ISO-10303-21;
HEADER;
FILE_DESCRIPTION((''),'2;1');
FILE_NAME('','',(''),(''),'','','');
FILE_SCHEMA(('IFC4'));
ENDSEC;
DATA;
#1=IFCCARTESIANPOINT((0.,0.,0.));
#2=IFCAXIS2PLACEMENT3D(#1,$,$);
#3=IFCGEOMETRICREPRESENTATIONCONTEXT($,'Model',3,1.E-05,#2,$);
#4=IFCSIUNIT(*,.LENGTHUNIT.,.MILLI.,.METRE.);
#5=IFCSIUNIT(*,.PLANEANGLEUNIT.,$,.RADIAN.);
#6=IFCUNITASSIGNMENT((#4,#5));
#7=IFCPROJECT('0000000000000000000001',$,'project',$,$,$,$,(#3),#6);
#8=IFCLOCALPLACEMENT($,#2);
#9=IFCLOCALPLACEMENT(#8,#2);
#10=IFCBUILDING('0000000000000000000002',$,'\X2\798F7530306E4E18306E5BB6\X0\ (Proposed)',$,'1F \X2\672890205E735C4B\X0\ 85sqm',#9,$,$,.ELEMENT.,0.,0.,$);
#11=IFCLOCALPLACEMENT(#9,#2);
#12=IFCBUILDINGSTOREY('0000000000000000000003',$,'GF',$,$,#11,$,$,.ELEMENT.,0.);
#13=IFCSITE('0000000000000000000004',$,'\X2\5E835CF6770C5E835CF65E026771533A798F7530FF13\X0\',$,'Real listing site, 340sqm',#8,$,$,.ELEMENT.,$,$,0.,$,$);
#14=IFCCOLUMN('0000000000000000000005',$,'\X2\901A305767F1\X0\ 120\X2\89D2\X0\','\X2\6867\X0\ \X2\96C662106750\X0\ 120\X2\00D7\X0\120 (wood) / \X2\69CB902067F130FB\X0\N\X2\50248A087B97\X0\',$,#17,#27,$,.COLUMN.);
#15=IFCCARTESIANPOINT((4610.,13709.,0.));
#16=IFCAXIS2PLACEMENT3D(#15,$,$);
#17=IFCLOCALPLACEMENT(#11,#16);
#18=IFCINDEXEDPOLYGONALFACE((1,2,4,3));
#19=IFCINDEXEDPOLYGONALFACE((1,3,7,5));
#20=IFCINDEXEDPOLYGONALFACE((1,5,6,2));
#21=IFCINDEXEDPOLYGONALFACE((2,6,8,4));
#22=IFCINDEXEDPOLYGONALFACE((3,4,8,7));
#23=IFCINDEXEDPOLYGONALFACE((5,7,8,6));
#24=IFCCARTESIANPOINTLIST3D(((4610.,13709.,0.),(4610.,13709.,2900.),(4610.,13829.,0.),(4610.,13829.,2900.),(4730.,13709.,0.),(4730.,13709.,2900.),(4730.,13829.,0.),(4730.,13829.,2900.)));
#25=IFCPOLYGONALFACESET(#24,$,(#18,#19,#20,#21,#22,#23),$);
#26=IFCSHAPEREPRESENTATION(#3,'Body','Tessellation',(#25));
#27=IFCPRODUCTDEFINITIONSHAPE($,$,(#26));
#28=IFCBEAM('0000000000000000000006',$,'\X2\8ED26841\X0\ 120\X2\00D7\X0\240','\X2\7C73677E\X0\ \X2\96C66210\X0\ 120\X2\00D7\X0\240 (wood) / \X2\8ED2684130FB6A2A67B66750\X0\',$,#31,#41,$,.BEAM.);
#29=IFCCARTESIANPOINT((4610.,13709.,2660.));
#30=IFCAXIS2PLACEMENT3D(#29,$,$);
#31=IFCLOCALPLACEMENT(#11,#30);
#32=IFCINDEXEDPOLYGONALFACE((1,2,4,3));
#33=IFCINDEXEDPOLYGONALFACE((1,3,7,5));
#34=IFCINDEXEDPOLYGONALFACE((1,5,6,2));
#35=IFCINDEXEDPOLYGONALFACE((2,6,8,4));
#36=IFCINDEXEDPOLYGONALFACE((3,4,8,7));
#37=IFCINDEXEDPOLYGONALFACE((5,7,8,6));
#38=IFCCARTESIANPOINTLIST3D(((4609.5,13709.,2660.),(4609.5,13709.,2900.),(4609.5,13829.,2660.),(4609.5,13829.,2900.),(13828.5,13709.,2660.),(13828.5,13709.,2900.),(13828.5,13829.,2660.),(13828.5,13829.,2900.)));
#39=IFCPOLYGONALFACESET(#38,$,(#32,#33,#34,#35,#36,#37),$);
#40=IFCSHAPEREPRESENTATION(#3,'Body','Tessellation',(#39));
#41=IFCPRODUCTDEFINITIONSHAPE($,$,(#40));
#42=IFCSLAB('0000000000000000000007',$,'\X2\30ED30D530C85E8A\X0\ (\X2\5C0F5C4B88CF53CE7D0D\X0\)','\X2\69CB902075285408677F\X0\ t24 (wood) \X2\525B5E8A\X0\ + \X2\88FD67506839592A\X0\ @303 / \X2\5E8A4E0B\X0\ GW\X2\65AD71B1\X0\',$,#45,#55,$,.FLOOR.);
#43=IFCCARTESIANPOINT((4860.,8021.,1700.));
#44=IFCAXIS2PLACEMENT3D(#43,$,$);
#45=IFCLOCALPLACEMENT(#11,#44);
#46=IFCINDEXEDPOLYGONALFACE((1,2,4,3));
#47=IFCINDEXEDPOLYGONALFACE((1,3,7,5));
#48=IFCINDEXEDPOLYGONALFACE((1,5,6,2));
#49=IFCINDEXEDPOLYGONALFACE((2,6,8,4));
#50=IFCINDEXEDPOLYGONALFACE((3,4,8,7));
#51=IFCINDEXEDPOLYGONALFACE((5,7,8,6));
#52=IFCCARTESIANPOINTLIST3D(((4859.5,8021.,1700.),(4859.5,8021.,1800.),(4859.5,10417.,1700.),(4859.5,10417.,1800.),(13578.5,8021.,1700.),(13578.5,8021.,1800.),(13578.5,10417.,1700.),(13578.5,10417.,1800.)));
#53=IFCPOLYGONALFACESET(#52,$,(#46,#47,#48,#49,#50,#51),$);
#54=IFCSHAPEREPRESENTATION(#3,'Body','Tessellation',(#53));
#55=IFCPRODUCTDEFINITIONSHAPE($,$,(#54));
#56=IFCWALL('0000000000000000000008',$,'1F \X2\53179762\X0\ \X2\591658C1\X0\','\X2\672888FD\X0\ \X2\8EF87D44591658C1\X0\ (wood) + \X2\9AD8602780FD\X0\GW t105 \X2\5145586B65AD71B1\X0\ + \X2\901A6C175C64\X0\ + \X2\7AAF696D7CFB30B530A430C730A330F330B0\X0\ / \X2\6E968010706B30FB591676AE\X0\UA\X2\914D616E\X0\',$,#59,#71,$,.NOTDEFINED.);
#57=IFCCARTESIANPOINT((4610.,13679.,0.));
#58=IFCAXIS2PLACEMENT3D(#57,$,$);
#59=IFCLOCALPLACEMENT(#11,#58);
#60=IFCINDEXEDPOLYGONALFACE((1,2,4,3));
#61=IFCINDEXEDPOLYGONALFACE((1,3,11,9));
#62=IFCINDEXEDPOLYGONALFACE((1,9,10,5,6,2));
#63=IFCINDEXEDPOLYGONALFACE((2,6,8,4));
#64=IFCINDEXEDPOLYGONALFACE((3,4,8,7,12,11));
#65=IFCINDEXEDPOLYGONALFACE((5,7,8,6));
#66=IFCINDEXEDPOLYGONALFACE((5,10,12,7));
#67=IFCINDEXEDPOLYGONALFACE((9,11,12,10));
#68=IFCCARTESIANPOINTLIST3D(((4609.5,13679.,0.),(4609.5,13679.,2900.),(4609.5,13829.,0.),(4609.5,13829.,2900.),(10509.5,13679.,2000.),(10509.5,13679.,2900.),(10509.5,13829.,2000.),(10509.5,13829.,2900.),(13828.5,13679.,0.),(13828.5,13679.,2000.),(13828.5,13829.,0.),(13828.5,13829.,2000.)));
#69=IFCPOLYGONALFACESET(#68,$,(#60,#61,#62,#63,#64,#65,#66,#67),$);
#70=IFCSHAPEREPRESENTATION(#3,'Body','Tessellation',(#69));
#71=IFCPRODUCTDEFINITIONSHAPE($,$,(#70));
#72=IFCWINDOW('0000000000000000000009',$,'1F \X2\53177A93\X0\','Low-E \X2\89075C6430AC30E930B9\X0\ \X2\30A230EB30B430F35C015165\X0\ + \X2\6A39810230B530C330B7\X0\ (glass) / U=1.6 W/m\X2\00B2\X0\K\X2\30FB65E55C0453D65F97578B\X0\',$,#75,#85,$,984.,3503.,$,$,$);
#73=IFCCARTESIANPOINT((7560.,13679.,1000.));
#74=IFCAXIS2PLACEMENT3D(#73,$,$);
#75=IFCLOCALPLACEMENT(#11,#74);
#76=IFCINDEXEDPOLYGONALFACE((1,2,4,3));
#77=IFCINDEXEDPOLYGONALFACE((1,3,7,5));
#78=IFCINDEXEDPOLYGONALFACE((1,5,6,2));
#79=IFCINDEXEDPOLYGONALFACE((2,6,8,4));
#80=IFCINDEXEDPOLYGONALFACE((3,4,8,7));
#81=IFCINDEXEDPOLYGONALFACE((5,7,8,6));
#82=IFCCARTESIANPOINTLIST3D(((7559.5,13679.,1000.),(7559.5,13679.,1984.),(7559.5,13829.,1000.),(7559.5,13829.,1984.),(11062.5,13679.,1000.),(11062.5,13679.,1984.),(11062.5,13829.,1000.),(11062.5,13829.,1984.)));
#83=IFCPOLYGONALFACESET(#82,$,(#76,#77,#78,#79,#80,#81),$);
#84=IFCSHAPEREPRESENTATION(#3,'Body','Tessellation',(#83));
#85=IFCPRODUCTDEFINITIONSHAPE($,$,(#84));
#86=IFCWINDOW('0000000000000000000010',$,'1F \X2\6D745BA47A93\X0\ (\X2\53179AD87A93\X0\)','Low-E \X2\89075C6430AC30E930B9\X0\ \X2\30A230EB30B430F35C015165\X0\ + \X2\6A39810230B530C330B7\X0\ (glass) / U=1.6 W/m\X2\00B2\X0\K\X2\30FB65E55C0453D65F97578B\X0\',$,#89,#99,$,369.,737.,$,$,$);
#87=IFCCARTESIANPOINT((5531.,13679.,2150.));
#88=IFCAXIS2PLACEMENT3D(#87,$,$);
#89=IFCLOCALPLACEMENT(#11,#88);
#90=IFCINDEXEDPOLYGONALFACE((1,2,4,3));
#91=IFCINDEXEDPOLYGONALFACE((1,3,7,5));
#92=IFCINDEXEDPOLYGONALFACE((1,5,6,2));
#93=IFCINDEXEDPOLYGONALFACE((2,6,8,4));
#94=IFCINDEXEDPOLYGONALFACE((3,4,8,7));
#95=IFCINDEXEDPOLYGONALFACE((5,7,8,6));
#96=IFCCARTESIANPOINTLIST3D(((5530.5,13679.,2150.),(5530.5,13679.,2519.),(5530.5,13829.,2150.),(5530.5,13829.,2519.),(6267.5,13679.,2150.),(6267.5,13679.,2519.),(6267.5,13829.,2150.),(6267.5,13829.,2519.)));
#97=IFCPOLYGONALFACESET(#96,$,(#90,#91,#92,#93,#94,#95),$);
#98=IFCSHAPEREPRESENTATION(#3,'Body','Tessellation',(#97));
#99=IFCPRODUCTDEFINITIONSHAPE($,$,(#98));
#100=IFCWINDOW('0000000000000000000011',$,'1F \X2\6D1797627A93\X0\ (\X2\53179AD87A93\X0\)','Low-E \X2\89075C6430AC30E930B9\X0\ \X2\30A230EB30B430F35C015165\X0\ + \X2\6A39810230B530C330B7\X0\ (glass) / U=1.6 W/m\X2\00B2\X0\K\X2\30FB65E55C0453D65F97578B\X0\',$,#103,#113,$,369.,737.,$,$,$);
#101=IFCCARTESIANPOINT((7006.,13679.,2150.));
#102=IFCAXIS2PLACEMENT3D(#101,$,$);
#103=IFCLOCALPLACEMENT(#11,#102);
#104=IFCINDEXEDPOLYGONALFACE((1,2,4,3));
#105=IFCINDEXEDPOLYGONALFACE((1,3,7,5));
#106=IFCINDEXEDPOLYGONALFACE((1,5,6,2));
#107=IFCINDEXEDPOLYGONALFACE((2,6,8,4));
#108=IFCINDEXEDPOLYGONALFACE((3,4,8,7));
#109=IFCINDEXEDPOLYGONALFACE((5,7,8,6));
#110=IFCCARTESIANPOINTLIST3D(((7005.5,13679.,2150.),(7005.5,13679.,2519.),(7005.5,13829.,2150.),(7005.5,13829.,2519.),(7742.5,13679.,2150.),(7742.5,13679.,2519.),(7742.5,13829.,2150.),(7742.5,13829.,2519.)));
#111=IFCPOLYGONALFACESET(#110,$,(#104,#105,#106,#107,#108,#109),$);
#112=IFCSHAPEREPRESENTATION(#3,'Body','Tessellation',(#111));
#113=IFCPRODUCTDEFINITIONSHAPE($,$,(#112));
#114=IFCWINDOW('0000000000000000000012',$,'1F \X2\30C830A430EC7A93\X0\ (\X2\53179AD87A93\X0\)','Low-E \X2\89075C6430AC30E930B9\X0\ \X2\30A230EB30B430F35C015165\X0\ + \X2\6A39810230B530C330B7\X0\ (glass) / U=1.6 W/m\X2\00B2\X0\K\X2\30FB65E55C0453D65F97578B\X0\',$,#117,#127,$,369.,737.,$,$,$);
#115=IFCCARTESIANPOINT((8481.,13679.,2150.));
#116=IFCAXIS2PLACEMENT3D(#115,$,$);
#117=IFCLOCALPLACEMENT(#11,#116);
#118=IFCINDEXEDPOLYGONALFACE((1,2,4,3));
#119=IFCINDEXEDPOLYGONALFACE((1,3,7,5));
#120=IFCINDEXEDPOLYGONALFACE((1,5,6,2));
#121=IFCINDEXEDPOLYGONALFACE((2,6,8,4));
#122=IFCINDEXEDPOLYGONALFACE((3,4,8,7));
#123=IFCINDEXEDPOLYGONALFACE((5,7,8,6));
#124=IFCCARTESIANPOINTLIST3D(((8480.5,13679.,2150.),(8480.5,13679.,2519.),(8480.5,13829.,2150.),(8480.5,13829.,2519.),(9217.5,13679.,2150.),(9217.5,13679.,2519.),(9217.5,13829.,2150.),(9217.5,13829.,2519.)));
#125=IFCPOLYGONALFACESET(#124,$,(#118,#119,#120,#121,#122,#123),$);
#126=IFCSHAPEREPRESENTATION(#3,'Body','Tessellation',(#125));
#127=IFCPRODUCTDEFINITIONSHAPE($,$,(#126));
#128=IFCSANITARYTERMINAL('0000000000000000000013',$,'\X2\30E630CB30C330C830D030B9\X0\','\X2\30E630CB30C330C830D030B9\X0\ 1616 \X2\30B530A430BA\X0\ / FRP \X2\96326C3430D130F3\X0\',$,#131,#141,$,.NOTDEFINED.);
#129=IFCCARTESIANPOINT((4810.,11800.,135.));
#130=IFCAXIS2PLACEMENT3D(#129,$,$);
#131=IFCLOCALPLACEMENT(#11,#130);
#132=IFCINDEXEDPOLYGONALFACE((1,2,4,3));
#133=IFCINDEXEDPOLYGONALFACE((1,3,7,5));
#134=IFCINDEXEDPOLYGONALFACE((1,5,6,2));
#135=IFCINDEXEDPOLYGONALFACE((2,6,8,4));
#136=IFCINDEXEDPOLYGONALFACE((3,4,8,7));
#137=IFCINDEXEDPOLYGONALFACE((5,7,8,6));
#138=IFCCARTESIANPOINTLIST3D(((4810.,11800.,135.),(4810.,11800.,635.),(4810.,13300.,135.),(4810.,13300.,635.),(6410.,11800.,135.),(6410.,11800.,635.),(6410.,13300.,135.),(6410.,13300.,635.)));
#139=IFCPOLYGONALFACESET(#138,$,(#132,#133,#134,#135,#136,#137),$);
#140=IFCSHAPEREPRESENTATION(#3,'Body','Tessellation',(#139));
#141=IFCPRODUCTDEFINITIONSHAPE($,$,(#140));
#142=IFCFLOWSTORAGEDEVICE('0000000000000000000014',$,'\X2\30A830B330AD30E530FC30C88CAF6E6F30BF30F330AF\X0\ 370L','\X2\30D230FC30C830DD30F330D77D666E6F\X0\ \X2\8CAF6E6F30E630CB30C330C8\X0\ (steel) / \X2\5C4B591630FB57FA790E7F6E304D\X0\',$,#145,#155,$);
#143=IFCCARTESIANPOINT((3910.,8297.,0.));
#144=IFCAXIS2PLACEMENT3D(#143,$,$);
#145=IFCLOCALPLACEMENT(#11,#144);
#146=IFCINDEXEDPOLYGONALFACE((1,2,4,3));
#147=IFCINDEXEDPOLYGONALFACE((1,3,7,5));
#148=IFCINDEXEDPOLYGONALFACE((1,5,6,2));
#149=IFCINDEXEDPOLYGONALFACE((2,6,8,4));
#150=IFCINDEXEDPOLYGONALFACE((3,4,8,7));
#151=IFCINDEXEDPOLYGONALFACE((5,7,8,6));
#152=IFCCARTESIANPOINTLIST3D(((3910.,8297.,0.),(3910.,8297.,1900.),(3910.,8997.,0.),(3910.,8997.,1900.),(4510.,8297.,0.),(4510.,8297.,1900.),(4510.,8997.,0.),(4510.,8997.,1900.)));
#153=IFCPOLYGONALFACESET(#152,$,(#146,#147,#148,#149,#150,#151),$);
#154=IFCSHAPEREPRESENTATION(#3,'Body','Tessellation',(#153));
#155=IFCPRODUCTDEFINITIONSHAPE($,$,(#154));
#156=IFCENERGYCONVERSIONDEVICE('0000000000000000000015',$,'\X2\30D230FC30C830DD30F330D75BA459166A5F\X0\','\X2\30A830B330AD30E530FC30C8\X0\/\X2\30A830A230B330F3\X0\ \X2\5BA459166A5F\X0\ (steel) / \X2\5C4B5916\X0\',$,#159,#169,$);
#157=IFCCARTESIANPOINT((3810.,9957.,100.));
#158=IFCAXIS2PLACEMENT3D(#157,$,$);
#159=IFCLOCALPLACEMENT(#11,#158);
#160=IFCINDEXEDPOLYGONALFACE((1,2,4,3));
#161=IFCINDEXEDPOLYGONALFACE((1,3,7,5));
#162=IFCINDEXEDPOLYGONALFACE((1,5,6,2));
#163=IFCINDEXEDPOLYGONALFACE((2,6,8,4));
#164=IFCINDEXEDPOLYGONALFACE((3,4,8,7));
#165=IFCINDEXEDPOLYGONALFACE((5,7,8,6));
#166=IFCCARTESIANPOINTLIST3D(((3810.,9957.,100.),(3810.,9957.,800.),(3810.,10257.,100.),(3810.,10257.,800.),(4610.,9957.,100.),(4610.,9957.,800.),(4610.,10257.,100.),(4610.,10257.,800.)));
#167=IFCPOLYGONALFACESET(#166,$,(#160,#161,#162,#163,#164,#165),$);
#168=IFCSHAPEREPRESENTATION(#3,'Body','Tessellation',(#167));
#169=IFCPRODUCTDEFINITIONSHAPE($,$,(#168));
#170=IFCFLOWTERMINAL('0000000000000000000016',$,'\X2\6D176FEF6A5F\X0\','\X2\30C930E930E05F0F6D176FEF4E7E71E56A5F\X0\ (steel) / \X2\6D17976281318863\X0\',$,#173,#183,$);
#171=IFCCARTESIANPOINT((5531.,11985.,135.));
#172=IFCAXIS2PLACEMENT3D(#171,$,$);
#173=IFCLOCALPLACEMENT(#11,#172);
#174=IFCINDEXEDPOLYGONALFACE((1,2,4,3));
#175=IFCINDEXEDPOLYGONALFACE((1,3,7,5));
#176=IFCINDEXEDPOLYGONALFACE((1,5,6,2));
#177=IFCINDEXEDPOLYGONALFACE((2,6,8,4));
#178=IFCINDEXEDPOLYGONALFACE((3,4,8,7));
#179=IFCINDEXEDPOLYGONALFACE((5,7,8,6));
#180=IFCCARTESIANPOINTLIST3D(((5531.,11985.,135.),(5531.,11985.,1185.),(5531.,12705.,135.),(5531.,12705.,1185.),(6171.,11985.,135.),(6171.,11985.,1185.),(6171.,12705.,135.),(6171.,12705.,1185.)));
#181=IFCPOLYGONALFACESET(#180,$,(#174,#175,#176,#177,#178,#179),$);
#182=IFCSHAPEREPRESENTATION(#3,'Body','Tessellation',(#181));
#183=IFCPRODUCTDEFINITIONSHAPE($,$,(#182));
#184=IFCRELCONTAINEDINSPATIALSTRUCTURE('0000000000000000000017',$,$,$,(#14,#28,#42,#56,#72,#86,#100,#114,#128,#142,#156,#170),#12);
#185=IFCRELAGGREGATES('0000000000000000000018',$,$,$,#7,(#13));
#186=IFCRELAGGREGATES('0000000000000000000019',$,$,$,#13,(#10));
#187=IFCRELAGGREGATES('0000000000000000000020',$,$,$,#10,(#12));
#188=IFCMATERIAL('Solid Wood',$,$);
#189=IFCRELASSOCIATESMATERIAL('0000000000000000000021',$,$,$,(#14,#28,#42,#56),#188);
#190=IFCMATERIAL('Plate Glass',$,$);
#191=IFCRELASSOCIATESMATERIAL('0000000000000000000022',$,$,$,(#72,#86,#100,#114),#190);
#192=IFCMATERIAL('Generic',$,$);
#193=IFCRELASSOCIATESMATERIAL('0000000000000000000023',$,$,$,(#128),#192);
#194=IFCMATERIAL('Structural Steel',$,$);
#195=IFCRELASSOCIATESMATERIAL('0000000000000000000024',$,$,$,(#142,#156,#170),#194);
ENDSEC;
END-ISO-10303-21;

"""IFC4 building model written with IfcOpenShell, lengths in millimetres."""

from ifc_helpers import new_model, si_unit, frame, frame_2d, origin, place, context, project, spatial, rectangle, extrude, material, element, fill, save


model = new_model("IFC4")

# Units and contexts
model_context = context("Model", 3, precision=1e-05, world=origin())
ifc_project = project(units=[si_unit("LENGTHUNIT", "METRE", prefix="MILLI"), si_unit("PLANEANGLEUNIT", "RADIAN")], contexts=[model_context])

# Site, building, storey
site_placement = place(None, origin())
site = spatial("IfcSite", under=ifc_project, at=site_placement, Name="広島県広島市東区福田３", ObjectType="Real listing site, 340sqm", CompositionType="ELEMENT", RefElevation=0.0)
building_placement = place(site_placement, origin())
building = spatial("IfcBuilding", under=site, at=building_placement, Name="福田の丘の家 (Proposed)", ObjectType="1F 木造平屋 85sqm", CompositionType="ELEMENT", ElevationOfRefHeight=0.0, ElevationOfTerrain=0.0)
storey_placement = place(building_placement, origin())
storey = spatial("IfcBuildingStorey", under=building, at=storey_placement, Name="GF", CompositionType="ELEMENT", Elevation=0.0)

# Column
ifc_material_1 = material(Name="Solid Wood")
column_1_placement = place(storey_placement, frame((4610.0, 13709.0, 0.0)))
element("IfcColumn", 1, at=column_1_placement, inside=storey, material=ifc_material_1, Name="通し柱 120角", Description="桧 集成材 120×120 (wood) / 構造柱・N値計算", PredefinedType="COLUMN", context=model_context, shape_type="SweptSolid", body=[
    extrude(rectangle(XDim=120.0, YDim=120.0, at=frame_2d((60.0, 60.0))), frame((4610.0, 13709.0, 0.0)), (0.0, 0.0, 1.0), 2900.0),
])

# Beam
beam_1_placement = place(storey_placement, frame((4610.0, 13709.0, 2660.0)))
element("IfcBeam", 2, at=beam_1_placement, inside=storey, material=ifc_material_1, Name="軒桁 120×240", Description="米松 集成 120×240 (wood) / 軒桁・横架材", PredefinedType="BEAM", context=model_context, shape_type="SweptSolid", body=[
    extrude(rectangle(XDim=9219.0, YDim=120.0, at=frame_2d((4609.0, 60.0))), frame((4610.0, 13709.0, 2660.0)), (0.0, 0.0, 1.0), 240.0),
])

# Slab
slab_placement = place(storey_placement, frame((4860.0, 8021.0, 1700.0)))
element("IfcSlab", 3, at=slab_placement, inside=storey, material=ifc_material_1, Name="ロフト床 (小屋裏収納)", Description="構造用合板 t24 (wood) 剛床 + 製材根太 @303 / 床下 GW断熱", PredefinedType="FLOOR", context=model_context, shape_type="SweptSolid", body=[
    extrude(rectangle(XDim=8719.0, YDim=2396.0, at=frame_2d((4359.0, 1198.0))), frame((4860.0, 8021.0, 1700.0)), (0.0, 0.0, 1.0), 100.0),
])

# Wall, openings, windows
wall_1_placement = place(storey_placement, frame((4610.0, 13679.0, 0.0)))
wall_1 = element("IfcWall", 4, at=wall_1_placement, inside=storey, material=ifc_material_1, Name="1F 北面 外壁", Description="木製 軸組外壁 (wood) + 高性能GW t105 充填断熱 + 通気層 + 窯業系サイディング / 準耐火・外皮UA配慮", PredefinedType="NOTDEFINED", context=model_context, shape_type="SweptSolid", body=[
    extrude(rectangle(XDim=9219.0, YDim=150.0, at=frame_2d((4609.0, 75.0))), frame((4610.0, 13679.0, 0.0)), (0.0, 0.0, 1.0), 2900.0),
])
opening_1_placement = place(storey_placement, frame((7560.0, 13679.0, 1000.0)))
opening_1 = element("IfcOpeningElement", 5, at=opening_1_placement, cuts=wall_1, PredefinedType="NOTDEFINED", context=model_context, shape_type="SweptSolid", body=[
    extrude(rectangle(XDim=3503.0, YDim=150.0, at=frame_2d((1751.0, 75.0))), frame((7560.0, 13679.0, 1000.0)), (0.0, 0.0, 1.0), 984.0),
])
opening_2_placement = place(storey_placement, frame((5531.0, 13679.0, 2150.0)))
opening_2 = element("IfcOpeningElement", 6, at=opening_2_placement, cuts=wall_1, PredefinedType="NOTDEFINED", context=model_context, shape_type="SweptSolid", body=[
    extrude(rectangle(XDim=737.0, YDim=150.0, at=frame_2d((368.0, 75.0))), frame((5531.0, 13679.0, 2150.0)), (0.0, 0.0, 1.0), 369.0),
])
opening_3_placement = place(storey_placement, frame((7006.0, 13679.0, 2150.0)))
opening_3 = element("IfcOpeningElement", 7, at=opening_3_placement, cuts=wall_1, PredefinedType="NOTDEFINED", context=model_context, shape_type="SweptSolid", body=[
    extrude(rectangle(XDim=737.0, YDim=150.0, at=frame_2d((368.0, 75.0))), frame((7006.0, 13679.0, 2150.0)), (0.0, 0.0, 1.0), 369.0),
])
opening_4_placement = place(storey_placement, frame((8481.0, 13679.0, 2150.0)))
opening_4 = element("IfcOpeningElement", 8, at=opening_4_placement, cuts=wall_1, PredefinedType="NOTDEFINED", context=model_context, shape_type="SweptSolid", body=[
    extrude(rectangle(XDim=737.0, YDim=150.0, at=frame_2d((368.0, 75.0))), frame((8481.0, 13679.0, 2150.0)), (0.0, 0.0, 1.0), 369.0),
])
ifc_material_2 = material(Name="Plate Glass")
window_1_placement = place(storey_placement, frame((7560.0, 13679.0, 1000.0)))
window_1 = element("IfcWindow", 9, at=window_1_placement, inside=storey, material=ifc_material_2, Name="1F 北窓", Description="Low-E 複層ガラス アルゴン封入 + 樹脂サッシ (glass) / U=1.6 W/m²K・日射取得型", OverallHeight=984.0, OverallWidth=3503.0, context=model_context, shape_type="SweptSolid", body=[
    extrude(rectangle(XDim=3503.0, YDim=150.0, at=frame_2d((1751.0, 75.0))), frame((7560.0, 13679.0, 1000.0)), (0.0, 0.0, 1.0), 984.0),
])
fill(opening_1, window_1)
window_2_placement = place(storey_placement, frame((5531.0, 13679.0, 2150.0)))
window_2 = element("IfcWindow", 10, at=window_2_placement, inside=storey, material=ifc_material_2, Name="1F 浴室窓 (北高窓)", Description="Low-E 複層ガラス アルゴン封入 + 樹脂サッシ (glass) / U=1.6 W/m²K・日射取得型", OverallHeight=369.0, OverallWidth=737.0, context=model_context, shape_type="SweptSolid", body=[
    extrude(rectangle(XDim=737.0, YDim=150.0, at=frame_2d((368.0, 75.0))), frame((5531.0, 13679.0, 2150.0)), (0.0, 0.0, 1.0), 369.0),
])
fill(opening_2, window_2)
window_3_placement = place(storey_placement, frame((7006.0, 13679.0, 2150.0)))
window_3 = element("IfcWindow", 11, at=window_3_placement, inside=storey, material=ifc_material_2, Name="1F 洗面窓 (北高窓)", Description="Low-E 複層ガラス アルゴン封入 + 樹脂サッシ (glass) / U=1.6 W/m²K・日射取得型", OverallHeight=369.0, OverallWidth=737.0, context=model_context, shape_type="SweptSolid", body=[
    extrude(rectangle(XDim=737.0, YDim=150.0, at=frame_2d((368.0, 75.0))), frame((7006.0, 13679.0, 2150.0)), (0.0, 0.0, 1.0), 369.0),
])
fill(opening_3, window_3)
window_4_placement = place(storey_placement, frame((8481.0, 13679.0, 2150.0)))
window_4 = element("IfcWindow", 12, at=window_4_placement, inside=storey, material=ifc_material_2, Name="1F トイレ窓 (北高窓)", Description="Low-E 複層ガラス アルゴン封入 + 樹脂サッシ (glass) / U=1.6 W/m²K・日射取得型", OverallHeight=369.0, OverallWidth=737.0, context=model_context, shape_type="SweptSolid", body=[
    extrude(rectangle(XDim=737.0, YDim=150.0, at=frame_2d((368.0, 75.0))), frame((8481.0, 13679.0, 2150.0)), (0.0, 0.0, 1.0), 369.0),
])
fill(opening_4, window_4)

# Sanitary terminal
ifc_material_3 = material(Name="Generic")
sanitary_terminal_placement = place(storey_placement, frame((4810.0, 11800.0, 135.0)))
element("IfcSanitaryTerminal", 13, at=sanitary_terminal_placement, inside=storey, material=ifc_material_3, Name="ユニットバス", Description="ユニットバス 1616 サイズ / FRP 防水パン", PredefinedType="NOTDEFINED", context=model_context, shape_type="SweptSolid", body=[
    extrude(rectangle(XDim=1600.0, YDim=1500.0, at=frame_2d((800.0, 750.0))), frame((4810.0, 11800.0, 135.0)), (0.0, 0.0, 1.0), 500.0),
])

# Flow storage device
ifc_material_4 = material(Name="Structural Steel")
flow_storage_device_placement = place(storey_placement, frame((3910.0, 8297.0, 0.0)))
element("IfcFlowStorageDevice", 14, at=flow_storage_device_placement, inside=storey, material=ifc_material_4, Name="エコキュート貯湯タンク 370L", Description="ヒートポンプ給湯 貯湯ユニット (steel) / 屋外・基礎置き", context=model_context, shape_type="SweptSolid", body=[
    extrude(rectangle(XDim=600.0, YDim=700.0, at=frame_2d((300.0, 350.0))), frame((3910.0, 8297.0, 0.0)), (0.0, 0.0, 1.0), 1900.0),
])

# Energy conversion device
energy_conversion_device_placement = place(storey_placement, frame((3810.0, 9957.0, 100.0)))
element("IfcEnergyConversionDevice", 15, at=energy_conversion_device_placement, inside=storey, material=ifc_material_4, Name="ヒートポンプ室外機", Description="エコキュート/エアコン 室外機 (steel) / 屋外", context=model_context, shape_type="SweptSolid", body=[
    extrude(rectangle(XDim=800.0, YDim=300.0, at=frame_2d((400.0, 150.0))), frame((3810.0, 9957.0, 100.0)), (0.0, 0.0, 1.0), 700.0),
])

# Flow terminal
flow_terminal_placement = place(storey_placement, frame((5531.0, 11985.0, 135.0)))
element("IfcFlowTerminal", 16, at=flow_terminal_placement, inside=storey, material=ifc_material_4, Name="洗濯機", Description="ドラム式洗濯乾燥機 (steel) / 洗面脱衣", context=model_context, shape_type="SweptSolid", body=[
    extrude(rectangle(XDim=640.0, YDim=720.0, at=frame_2d((320.0, 360.0))), frame((5531.0, 11985.0, 135.0)), (0.0, 0.0, 1.0), 1050.0),
])

save(model, "model.ifc")
